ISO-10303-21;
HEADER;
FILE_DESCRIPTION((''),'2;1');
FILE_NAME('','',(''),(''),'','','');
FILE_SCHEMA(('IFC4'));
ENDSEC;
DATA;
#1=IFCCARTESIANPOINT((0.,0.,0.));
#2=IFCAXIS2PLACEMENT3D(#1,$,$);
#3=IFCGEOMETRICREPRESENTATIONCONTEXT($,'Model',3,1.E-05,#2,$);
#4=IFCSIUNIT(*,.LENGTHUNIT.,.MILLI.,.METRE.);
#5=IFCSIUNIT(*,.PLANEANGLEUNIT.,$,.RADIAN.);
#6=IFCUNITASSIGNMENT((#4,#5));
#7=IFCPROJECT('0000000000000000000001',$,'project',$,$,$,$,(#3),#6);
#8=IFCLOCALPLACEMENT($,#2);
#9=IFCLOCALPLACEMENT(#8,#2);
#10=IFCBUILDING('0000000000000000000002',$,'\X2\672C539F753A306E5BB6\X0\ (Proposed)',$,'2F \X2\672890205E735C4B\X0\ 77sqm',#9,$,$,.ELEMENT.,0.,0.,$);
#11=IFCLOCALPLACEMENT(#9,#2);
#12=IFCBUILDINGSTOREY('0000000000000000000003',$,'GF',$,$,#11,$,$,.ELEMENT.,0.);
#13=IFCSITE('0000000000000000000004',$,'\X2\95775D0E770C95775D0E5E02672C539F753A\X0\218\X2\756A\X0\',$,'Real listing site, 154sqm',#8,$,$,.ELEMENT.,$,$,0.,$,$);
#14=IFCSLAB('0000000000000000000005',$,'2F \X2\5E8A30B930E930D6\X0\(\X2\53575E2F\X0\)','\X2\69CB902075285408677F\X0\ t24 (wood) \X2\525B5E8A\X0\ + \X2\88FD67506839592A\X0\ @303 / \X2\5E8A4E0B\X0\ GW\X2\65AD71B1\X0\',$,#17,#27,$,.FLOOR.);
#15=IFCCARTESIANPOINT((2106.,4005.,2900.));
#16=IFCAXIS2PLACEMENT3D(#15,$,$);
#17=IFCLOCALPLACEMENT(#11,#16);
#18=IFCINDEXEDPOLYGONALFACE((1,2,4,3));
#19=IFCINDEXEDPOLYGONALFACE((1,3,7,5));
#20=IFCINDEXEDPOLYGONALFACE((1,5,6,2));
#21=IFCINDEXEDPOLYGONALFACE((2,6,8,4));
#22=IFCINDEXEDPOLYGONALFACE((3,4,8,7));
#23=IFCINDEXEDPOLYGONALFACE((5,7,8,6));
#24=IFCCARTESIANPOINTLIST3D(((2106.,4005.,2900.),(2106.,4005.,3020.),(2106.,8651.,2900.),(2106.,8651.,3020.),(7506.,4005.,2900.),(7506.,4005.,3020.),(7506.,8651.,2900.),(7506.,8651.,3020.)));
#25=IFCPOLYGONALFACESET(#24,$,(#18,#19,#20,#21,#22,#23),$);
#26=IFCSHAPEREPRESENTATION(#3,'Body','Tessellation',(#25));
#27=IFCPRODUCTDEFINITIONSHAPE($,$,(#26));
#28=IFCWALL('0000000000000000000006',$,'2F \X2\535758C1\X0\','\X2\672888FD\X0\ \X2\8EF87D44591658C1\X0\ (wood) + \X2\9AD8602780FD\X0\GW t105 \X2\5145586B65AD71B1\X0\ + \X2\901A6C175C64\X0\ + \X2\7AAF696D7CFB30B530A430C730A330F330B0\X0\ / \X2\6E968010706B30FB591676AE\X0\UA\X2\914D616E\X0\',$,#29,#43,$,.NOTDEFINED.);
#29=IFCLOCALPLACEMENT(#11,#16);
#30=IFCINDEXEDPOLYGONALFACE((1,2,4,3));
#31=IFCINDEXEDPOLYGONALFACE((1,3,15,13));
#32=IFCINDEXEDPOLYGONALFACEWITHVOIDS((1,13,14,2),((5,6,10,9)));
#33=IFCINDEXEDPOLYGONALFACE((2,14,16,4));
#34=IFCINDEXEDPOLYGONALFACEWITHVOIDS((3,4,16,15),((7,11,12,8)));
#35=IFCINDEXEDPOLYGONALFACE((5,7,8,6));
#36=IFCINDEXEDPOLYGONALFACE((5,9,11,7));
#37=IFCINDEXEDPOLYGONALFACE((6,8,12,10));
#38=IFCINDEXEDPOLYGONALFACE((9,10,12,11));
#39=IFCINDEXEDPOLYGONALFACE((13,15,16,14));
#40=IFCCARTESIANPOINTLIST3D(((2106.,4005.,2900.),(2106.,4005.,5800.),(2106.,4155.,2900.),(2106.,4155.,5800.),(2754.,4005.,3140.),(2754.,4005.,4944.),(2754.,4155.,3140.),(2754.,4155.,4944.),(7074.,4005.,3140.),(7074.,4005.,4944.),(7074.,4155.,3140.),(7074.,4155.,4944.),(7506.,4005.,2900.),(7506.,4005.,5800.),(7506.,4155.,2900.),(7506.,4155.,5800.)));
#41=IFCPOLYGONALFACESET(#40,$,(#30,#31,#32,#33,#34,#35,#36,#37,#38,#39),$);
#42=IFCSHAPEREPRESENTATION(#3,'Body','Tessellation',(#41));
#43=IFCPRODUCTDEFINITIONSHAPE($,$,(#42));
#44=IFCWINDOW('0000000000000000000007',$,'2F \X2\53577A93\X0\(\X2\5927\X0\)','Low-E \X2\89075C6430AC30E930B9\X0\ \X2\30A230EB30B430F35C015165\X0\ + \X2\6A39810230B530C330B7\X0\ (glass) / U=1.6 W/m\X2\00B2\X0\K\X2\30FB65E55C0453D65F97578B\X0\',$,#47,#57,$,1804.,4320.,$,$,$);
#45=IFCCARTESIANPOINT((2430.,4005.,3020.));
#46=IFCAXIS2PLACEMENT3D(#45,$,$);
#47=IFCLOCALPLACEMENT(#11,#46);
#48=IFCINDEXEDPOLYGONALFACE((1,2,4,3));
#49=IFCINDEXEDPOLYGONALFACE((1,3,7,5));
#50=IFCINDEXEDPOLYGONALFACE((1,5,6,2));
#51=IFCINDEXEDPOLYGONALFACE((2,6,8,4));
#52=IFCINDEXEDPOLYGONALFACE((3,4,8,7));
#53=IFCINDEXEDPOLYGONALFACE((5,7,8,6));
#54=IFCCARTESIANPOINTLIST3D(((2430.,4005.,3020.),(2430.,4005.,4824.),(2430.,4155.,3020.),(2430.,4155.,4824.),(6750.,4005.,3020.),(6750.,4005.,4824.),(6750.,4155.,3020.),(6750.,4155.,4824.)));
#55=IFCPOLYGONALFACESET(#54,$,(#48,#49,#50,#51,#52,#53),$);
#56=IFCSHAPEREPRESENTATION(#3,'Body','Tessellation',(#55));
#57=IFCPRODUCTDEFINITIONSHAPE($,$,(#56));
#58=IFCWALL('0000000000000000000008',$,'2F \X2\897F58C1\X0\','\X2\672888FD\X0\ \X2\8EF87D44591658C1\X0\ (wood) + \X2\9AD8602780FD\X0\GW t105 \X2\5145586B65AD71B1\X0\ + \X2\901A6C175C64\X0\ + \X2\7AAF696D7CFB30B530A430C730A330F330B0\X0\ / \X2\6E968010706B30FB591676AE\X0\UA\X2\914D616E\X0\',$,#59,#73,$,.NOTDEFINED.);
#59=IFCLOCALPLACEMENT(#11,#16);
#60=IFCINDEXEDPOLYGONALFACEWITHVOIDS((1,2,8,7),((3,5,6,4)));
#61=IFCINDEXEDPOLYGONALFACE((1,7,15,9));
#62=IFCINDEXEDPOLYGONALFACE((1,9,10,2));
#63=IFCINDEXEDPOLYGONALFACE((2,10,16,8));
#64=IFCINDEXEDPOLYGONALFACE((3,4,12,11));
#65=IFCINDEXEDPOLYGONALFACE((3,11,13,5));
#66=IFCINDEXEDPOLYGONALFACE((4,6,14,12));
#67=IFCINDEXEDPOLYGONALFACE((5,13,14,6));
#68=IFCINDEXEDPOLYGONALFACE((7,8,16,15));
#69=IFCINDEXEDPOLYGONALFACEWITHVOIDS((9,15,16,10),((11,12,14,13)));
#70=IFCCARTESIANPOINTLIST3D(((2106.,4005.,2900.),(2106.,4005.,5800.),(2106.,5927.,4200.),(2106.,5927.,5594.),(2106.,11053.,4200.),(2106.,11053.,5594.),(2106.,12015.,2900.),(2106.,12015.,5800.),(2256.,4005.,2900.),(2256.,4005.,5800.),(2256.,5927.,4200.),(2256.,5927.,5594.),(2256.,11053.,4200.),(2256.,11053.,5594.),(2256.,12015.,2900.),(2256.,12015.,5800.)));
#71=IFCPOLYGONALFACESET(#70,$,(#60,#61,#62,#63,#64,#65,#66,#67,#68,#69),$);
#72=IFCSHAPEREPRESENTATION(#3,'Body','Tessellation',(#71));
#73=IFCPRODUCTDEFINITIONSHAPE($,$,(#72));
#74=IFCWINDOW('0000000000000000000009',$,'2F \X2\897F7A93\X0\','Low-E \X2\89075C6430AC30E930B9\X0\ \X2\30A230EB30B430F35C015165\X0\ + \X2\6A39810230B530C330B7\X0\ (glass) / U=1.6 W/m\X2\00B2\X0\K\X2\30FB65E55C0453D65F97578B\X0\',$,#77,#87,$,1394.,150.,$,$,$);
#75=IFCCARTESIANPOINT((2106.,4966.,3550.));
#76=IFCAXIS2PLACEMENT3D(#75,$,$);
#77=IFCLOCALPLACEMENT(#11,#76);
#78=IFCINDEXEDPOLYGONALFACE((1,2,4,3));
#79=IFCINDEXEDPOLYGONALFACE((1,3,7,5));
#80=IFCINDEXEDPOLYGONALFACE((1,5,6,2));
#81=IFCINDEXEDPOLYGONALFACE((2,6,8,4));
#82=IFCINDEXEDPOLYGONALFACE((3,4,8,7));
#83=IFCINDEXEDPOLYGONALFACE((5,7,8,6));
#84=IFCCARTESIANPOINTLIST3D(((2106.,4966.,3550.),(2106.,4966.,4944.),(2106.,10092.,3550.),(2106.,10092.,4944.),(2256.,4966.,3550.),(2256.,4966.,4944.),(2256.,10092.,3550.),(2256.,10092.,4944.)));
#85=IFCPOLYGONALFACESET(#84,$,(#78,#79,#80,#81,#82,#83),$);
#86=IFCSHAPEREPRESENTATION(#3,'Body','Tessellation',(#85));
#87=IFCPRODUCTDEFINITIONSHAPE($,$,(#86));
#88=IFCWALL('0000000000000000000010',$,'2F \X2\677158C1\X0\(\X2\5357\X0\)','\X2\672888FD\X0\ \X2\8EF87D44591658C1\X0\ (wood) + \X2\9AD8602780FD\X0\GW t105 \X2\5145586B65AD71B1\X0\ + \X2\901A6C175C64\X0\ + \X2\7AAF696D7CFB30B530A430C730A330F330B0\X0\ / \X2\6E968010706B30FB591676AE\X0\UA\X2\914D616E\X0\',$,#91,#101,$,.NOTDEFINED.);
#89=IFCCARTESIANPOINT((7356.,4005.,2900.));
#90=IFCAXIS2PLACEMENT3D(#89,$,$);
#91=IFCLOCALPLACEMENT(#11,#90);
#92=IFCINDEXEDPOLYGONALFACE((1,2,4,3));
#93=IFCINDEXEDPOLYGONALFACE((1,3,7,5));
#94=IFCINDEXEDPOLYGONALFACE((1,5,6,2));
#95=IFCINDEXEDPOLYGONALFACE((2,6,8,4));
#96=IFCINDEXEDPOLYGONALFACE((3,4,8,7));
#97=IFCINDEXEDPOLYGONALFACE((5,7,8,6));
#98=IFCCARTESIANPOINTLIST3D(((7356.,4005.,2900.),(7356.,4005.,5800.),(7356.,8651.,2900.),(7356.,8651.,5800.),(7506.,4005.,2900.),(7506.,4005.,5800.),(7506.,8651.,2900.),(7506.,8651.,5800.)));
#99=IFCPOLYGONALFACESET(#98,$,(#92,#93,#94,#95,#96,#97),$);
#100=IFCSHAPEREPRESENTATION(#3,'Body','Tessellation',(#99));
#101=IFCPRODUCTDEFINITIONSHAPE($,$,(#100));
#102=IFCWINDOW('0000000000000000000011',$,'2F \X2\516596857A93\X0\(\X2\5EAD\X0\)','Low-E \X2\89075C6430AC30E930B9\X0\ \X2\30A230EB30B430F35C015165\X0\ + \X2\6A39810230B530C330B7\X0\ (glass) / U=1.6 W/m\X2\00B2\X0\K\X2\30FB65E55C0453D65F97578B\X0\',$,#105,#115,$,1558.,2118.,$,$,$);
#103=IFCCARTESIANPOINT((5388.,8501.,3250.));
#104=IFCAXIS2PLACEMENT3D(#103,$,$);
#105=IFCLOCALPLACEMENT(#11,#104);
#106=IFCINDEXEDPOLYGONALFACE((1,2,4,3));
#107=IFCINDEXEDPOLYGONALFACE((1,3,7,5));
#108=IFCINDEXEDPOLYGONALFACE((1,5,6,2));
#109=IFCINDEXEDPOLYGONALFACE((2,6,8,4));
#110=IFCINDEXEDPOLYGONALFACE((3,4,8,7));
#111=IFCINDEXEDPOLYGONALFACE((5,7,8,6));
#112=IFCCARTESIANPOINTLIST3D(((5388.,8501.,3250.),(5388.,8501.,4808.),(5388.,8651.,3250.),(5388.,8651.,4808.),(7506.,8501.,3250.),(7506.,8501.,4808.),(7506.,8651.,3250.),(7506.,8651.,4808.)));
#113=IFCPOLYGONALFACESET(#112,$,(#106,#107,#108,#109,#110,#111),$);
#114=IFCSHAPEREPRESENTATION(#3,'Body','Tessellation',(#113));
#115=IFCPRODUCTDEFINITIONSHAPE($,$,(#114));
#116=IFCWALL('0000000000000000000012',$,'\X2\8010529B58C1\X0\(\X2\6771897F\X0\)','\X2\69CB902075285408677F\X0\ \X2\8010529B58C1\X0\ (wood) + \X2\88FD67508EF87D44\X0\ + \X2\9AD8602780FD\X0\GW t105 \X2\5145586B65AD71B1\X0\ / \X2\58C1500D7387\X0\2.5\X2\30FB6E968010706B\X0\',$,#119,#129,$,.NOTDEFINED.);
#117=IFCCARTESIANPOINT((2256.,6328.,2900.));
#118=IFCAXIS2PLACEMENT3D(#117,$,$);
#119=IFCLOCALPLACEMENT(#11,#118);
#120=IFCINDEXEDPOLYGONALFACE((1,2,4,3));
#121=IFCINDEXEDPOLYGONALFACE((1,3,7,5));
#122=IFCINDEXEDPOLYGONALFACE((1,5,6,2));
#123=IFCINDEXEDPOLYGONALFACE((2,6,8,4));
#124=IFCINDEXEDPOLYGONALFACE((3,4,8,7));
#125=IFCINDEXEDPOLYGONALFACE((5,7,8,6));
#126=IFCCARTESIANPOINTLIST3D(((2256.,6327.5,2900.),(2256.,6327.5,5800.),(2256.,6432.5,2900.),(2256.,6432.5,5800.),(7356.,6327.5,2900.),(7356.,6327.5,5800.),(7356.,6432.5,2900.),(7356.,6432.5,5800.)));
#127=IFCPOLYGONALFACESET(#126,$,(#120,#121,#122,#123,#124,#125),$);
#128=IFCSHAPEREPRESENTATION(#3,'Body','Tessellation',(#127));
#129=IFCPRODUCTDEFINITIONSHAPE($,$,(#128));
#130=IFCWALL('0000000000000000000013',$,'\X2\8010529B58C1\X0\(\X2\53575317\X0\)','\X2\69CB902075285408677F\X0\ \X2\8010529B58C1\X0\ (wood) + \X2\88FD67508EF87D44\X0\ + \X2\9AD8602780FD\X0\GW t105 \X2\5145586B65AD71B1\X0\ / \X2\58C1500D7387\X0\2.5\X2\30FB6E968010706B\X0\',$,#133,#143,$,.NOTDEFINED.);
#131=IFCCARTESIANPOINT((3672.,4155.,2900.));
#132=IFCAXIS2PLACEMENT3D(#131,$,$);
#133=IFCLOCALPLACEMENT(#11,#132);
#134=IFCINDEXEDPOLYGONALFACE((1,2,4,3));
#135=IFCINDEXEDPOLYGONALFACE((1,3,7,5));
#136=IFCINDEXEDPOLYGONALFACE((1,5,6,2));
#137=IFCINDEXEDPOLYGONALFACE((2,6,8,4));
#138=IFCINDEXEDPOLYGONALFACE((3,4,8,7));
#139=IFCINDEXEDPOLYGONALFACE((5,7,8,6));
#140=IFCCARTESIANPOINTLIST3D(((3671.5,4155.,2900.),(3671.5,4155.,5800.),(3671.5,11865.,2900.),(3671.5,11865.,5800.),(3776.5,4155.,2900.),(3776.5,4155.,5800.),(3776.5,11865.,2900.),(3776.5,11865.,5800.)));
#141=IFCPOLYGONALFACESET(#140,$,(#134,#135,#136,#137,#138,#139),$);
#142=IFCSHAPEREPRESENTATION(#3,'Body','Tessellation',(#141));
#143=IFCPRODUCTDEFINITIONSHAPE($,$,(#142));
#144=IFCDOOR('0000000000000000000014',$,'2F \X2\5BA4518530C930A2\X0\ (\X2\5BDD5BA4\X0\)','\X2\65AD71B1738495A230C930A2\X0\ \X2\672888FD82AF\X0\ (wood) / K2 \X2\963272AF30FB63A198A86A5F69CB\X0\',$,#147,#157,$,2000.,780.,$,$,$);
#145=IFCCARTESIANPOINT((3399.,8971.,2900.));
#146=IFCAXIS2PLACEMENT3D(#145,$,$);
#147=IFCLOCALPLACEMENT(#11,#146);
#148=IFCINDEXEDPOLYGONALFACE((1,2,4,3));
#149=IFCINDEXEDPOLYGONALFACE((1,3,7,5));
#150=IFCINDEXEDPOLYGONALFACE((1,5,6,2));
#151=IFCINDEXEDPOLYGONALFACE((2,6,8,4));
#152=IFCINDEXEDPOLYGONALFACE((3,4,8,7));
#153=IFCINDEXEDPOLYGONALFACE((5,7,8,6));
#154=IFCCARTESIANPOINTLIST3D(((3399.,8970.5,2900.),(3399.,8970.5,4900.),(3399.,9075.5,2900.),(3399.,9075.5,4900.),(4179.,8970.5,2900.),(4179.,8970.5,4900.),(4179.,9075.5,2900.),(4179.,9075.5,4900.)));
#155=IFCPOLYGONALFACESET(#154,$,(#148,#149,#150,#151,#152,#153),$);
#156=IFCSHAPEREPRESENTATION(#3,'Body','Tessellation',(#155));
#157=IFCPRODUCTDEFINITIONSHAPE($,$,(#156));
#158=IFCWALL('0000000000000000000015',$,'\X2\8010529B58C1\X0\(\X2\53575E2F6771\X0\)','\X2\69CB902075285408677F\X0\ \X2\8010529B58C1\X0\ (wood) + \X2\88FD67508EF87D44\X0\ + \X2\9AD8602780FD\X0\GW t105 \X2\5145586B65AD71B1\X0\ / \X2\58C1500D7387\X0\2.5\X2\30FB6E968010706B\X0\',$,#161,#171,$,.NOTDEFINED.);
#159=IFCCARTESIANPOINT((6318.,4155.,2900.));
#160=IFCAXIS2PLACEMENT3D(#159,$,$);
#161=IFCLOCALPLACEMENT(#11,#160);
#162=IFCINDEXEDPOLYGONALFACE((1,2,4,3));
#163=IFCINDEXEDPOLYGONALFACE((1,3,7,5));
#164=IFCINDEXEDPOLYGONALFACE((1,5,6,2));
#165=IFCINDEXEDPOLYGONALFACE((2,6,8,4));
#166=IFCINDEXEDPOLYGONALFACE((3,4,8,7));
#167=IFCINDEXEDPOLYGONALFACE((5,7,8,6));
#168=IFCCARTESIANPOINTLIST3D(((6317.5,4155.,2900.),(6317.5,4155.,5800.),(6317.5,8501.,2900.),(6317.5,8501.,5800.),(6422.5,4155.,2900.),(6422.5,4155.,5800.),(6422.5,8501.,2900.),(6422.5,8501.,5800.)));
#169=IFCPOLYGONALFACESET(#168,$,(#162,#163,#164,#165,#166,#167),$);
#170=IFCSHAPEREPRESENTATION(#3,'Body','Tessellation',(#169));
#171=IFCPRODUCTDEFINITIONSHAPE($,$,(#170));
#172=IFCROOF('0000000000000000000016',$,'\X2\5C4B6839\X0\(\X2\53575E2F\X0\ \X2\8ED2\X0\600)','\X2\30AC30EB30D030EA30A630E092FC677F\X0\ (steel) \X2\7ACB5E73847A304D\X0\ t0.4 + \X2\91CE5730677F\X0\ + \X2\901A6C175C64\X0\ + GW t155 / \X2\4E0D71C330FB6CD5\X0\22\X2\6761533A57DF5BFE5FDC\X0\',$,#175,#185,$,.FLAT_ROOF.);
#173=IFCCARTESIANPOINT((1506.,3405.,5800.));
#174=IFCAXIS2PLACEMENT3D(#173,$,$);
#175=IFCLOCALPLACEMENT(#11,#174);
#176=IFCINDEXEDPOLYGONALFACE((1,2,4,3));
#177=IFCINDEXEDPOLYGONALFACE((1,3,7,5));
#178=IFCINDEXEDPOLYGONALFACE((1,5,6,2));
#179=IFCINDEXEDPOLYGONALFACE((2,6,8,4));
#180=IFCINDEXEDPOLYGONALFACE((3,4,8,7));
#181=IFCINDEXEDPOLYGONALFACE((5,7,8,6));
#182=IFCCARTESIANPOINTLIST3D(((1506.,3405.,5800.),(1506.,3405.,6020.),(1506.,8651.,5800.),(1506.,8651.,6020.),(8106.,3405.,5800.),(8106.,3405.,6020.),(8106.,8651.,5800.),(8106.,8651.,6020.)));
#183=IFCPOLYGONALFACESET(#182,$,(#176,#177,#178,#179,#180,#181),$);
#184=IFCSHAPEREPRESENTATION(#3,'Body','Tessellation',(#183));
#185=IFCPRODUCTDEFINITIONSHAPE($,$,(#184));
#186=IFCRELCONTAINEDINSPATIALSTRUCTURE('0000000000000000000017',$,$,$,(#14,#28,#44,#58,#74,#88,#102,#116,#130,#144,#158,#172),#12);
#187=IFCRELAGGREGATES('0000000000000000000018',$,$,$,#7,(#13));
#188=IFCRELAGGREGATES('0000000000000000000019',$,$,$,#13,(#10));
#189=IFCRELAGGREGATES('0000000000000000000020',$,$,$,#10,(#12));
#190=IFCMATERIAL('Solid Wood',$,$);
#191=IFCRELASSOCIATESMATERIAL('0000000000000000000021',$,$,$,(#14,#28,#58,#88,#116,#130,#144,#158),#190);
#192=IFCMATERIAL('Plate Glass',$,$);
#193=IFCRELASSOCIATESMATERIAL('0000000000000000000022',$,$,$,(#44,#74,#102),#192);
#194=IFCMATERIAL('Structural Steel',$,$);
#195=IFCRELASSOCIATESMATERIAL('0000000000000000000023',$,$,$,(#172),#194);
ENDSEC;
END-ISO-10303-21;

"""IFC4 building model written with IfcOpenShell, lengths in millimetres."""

from ifc_helpers import new_model, si_unit, frame, frame_2d, origin, place, context, project, spatial, rectangle, extrude, material, element, fill, save


model = new_model("IFC4")

# Units and contexts
model_context = context("Model", 3, precision=1e-05, world=origin())
ifc_project = project(units=[si_unit("LENGTHUNIT", "METRE", prefix="MILLI"), si_unit("PLANEANGLEUNIT", "RADIAN")], contexts=[model_context])

# Site, building, storey
site_placement = place(None, origin())
site = spatial("IfcSite", under=ifc_project, at=site_placement, Name="長崎県長崎市本原町218番", ObjectType="Real listing site, 154sqm", CompositionType="ELEMENT", RefElevation=0.0)
building_placement = place(site_placement, origin())
building = spatial("IfcBuilding", under=site, at=building_placement, Name="本原町の家 (Proposed)", ObjectType="2F 木造平屋 77sqm", CompositionType="ELEMENT", ElevationOfRefHeight=0.0, ElevationOfTerrain=0.0)
storey_placement = place(building_placement, origin())
storey = spatial("IfcBuildingStorey", under=building, at=storey_placement, Name="GF", CompositionType="ELEMENT", Elevation=0.0)

# Slab
ifc_material_1 = material(Name="Solid Wood")
slab_placement = place(storey_placement, frame((2106.0, 4005.0, 2900.0)))
element("IfcSlab", 1, at=slab_placement, inside=storey, material=ifc_material_1, Name="2F 床スラブ(南帯)", Description="構造用合板 t24 (wood) 剛床 + 製材根太 @303 / 床下 GW断熱", PredefinedType="FLOOR", context=model_context, shape_type="SweptSolid", body=[
    extrude(rectangle(XDim=5400.0, YDim=4646.0, at=frame_2d((2700.0, 2323.0))), frame((2106.0, 4005.0, 2900.0)), (0.0, 0.0, 1.0), 120.0),
])

# Walls, openings, windows
wall_1_placement = place(storey_placement, frame((2106.0, 4005.0, 2900.0)))
wall_1 = element("IfcWall", 2, at=wall_1_placement, inside=storey, material=ifc_material_1, Name="2F 南壁", Description="木製 軸組外壁 (wood) + 高性能GW t105 充填断熱 + 通気層 + 窯業系サイディング / 準耐火・外皮UA配慮", PredefinedType="NOTDEFINED", context=model_context, shape_type="SweptSolid", body=[
    extrude(rectangle(XDim=5400.0, YDim=150.0, at=frame_2d((2700.0, 75.0))), frame((2106.0, 4005.0, 2900.0)), (0.0, 0.0, 1.0), 2900.0),
])
opening_1_placement = place(storey_placement, frame((2430.0, 4005.0, 3020.0)))
opening_1 = element("IfcOpeningElement", 3, at=opening_1_placement, cuts=wall_1, PredefinedType="NOTDEFINED", context=model_context, shape_type="SweptSolid", body=[
    extrude(rectangle(XDim=4320.0, YDim=150.0, at=frame_2d((2160.0, 75.0))), frame((2430.0, 4005.0, 3020.0)), (0.0, 0.0, 1.0), 1804.0),
])
ifc_material_2 = material(Name="Plate Glass")
window_1_placement = place(storey_placement, frame((2430.0, 4005.0, 3020.0)))
window_1 = element("IfcWindow", 4, at=window_1_placement, inside=storey, material=ifc_material_2, Name="2F 南窓(大)", Description="Low-E 複層ガラス アルゴン封入 + 樹脂サッシ (glass) / U=1.6 W/m²K・日射取得型", OverallHeight=1804.0, OverallWidth=4320.0, context=model_context, shape_type="SweptSolid", body=[
    extrude(rectangle(XDim=4320.0, YDim=150.0, at=frame_2d((2160.0, 75.0))), frame((2430.0, 4005.0, 3020.0)), (0.0, 0.0, 1.0), 1804.0),
])
fill(opening_1, window_1)
wall_2_placement = place(storey_placement, frame((2106.0, 4005.0, 2900.0)))
wall_2 = element("IfcWall", 5, at=wall_2_placement, inside=storey, material=ifc_material_1, Name="2F 西壁", Description="木製 軸組外壁 (wood) + 高性能GW t105 充填断熱 + 通気層 + 窯業系サイディング / 準耐火・外皮UA配慮", PredefinedType="NOTDEFINED", context=model_context, shape_type="SweptSolid", body=[
    extrude(rectangle(XDim=150.0, YDim=8010.0, at=frame_2d((75.0, 4005.0))), frame((2106.0, 4005.0, 2900.0)), (0.0, 0.0, 1.0), 2900.0),
])
opening_2_placement = place(storey_placement, frame((2106.0, 4966.0, 3550.0)))
opening_2 = element("IfcOpeningElement", 6, at=opening_2_placement, cuts=wall_2, PredefinedType="NOTDEFINED", context=model_context, shape_type="SweptSolid", body=[
    extrude(rectangle(XDim=150.0, YDim=5126.0, at=frame_2d((75.0, 2563.0))), frame((2106.0, 4966.0, 3550.0)), (0.0, 0.0, 1.0), 1394.0),
])
window_2_placement = place(storey_placement, frame((2106.0, 4966.0, 3550.0)))
window_2 = element("IfcWindow", 7, at=window_2_placement, inside=storey, material=ifc_material_2, Name="2F 西窓", Description="Low-E 複層ガラス アルゴン封入 + 樹脂サッシ (glass) / U=1.6 W/m²K・日射取得型", OverallHeight=1394.0, OverallWidth=150.0, context=model_context, shape_type="SweptSolid", body=[
    extrude(rectangle(XDim=150.0, YDim=5126.0, at=frame_2d((75.0, 2563.0))), frame((2106.0, 4966.0, 3550.0)), (0.0, 0.0, 1.0), 1394.0),
])
fill(opening_2, window_2)
wall_3_placement = place(storey_placement, frame((7356.0, 4005.0, 2900.0)))
wall_3 = element("IfcWall", 8, at=wall_3_placement, inside=storey, material=ifc_material_1, Name="2F 東壁(南)", Description="木製 軸組外壁 (wood) + 高性能GW t105 充填断熱 + 通気層 + 窯業系サイディング / 準耐火・外皮UA配慮", PredefinedType="NOTDEFINED", context=model_context, shape_type="SweptSolid", body=[
    extrude(rectangle(XDim=150.0, YDim=4646.0, at=frame_2d((75.0, 2323.0))), frame((7356.0, 4005.0, 2900.0)), (0.0, 0.0, 1.0), 2900.0),
])
opening_3_placement = place(storey_placement, frame((5388.0, 8501.0, 3250.0)))
opening_3 = element("IfcOpeningElement", 9, at=opening_3_placement, cuts=wall_3, PredefinedType="NOTDEFINED", context=model_context, shape_type="SweptSolid", body=[
    extrude(rectangle(XDim=2118.0, YDim=150.0, at=frame_2d((1059.0, 75.0))), frame((5388.0, 8501.0, 3250.0)), (0.0, 0.0, 1.0), 1558.0),
])
window_3_placement = place(storey_placement, frame((5388.0, 8501.0, 3250.0)))
window_3 = element("IfcWindow", 10, at=window_3_placement, inside=storey, material=ifc_material_2, Name="2F 入隅窓(庭)", Description="Low-E 複層ガラス アルゴン封入 + 樹脂サッシ (glass) / U=1.6 W/m²K・日射取得型", OverallHeight=1558.0, OverallWidth=2118.0, context=model_context, shape_type="SweptSolid", body=[
    extrude(rectangle(XDim=2118.0, YDim=150.0, at=frame_2d((1059.0, 75.0))), frame((5388.0, 8501.0, 3250.0)), (0.0, 0.0, 1.0), 1558.0),
])
fill(opening_3, window_3)

# Wall
wall_4_placement = place(storey_placement, frame((2256.0, 6328.0, 2900.0)))
element("IfcWall", 11, at=wall_4_placement, inside=storey, material=ifc_material_1, Name="耐力壁(東西)", Description="構造用合板 耐力壁 (wood) + 製材軸組 + 高性能GW t105 充填断熱 / 壁倍率2.5・準耐火", PredefinedType="NOTDEFINED", context=model_context, shape_type="SweptSolid", body=[
    extrude(rectangle(XDim=5100.0, YDim=105.0, at=frame_2d((2550.0, 52.0))), frame((2256.0, 6328.0, 2900.0)), (0.0, 0.0, 1.0), 2900.0),
])

# Wall, opening, door
wall_5_placement = place(storey_placement, frame((3672.0, 4155.0, 2900.0)))
wall_5 = element("IfcWall", 12, at=wall_5_placement, inside=storey, material=ifc_material_1, Name="耐力壁(南北)", Description="構造用合板 耐力壁 (wood) + 製材軸組 + 高性能GW t105 充填断熱 / 壁倍率2.5・準耐火", PredefinedType="NOTDEFINED", context=model_context, shape_type="SweptSolid", body=[
    extrude(rectangle(XDim=105.0, YDim=7710.0, at=frame_2d((52.0, 3855.0))), frame((3672.0, 4155.0, 2900.0)), (0.0, 0.0, 1.0), 2900.0),
])
opening_4_placement = place(storey_placement, frame((3399.0, 8971.0, 2900.0)))
opening_4 = element("IfcOpeningElement", 13, at=opening_4_placement, cuts=wall_5, PredefinedType="NOTDEFINED", context=model_context, shape_type="SweptSolid", body=[
    extrude(rectangle(XDim=780.0, YDim=105.0, at=frame_2d((390.0, 52.0))), frame((3399.0, 8971.0, 2900.0)), (0.0, 0.0, 1.0), 2000.0),
])
door_placement = place(storey_placement, frame((3399.0, 8971.0, 2900.0)))
door = element("IfcDoor", 14, at=door_placement, inside=storey, material=ifc_material_1, Name="2F 室内ドア (寝室)", Description="断熱玄関ドア 木製芯 (wood) / K2 防犯・採風機構", OverallHeight=2000.0, OverallWidth=780.0, context=model_context, shape_type="SweptSolid", body=[
    extrude(rectangle(XDim=780.0, YDim=105.0, at=frame_2d((390.0, 52.0))), frame((3399.0, 8971.0, 2900.0)), (0.0, 0.0, 1.0), 2000.0),
])
fill(opening_4, door)

# Wall
wall_6_placement = place(storey_placement, frame((6318.0, 4155.0, 2900.0)))
element("IfcWall", 15, at=wall_6_placement, inside=storey, material=ifc_material_1, Name="耐力壁(南帯東)", Description="構造用合板 耐力壁 (wood) + 製材軸組 + 高性能GW t105 充填断熱 / 壁倍率2.5・準耐火", PredefinedType="NOTDEFINED", context=model_context, shape_type="SweptSolid", body=[
    extrude(rectangle(XDim=105.0, YDim=4346.0, at=frame_2d((52.0, 2173.0))), frame((6318.0, 4155.0, 2900.0)), (0.0, 0.0, 1.0), 2900.0),
])

# Roof
ifc_material_3 = material(Name="Structural Steel")
for number, where, name in (
    (16, (1506.0, 3405.0, 5800.0), "屋根(南帯 軒600)"),
):
    element("IfcRoof", number, at=place(storey_placement, frame(where)), inside=storey, material=ifc_material_3, Name=name, Description="ガルバリウム鋼板 (steel) 立平葺き t0.4 + 野地板 + 通気層 + GW t155 / 不燃・法22条区域対応", PredefinedType="FLAT_ROOF", context=model_context, shape_type="SweptSolid", body=[
        extrude(rectangle(XDim=6600.0, YDim=5246.0, at=frame_2d((3300.0, 2623.0))), frame((1506.0, 3405.0, 5800.0)), (0.0, 0.0, 1.0), 220.0),
    ])

save(model, "model.ifc")
